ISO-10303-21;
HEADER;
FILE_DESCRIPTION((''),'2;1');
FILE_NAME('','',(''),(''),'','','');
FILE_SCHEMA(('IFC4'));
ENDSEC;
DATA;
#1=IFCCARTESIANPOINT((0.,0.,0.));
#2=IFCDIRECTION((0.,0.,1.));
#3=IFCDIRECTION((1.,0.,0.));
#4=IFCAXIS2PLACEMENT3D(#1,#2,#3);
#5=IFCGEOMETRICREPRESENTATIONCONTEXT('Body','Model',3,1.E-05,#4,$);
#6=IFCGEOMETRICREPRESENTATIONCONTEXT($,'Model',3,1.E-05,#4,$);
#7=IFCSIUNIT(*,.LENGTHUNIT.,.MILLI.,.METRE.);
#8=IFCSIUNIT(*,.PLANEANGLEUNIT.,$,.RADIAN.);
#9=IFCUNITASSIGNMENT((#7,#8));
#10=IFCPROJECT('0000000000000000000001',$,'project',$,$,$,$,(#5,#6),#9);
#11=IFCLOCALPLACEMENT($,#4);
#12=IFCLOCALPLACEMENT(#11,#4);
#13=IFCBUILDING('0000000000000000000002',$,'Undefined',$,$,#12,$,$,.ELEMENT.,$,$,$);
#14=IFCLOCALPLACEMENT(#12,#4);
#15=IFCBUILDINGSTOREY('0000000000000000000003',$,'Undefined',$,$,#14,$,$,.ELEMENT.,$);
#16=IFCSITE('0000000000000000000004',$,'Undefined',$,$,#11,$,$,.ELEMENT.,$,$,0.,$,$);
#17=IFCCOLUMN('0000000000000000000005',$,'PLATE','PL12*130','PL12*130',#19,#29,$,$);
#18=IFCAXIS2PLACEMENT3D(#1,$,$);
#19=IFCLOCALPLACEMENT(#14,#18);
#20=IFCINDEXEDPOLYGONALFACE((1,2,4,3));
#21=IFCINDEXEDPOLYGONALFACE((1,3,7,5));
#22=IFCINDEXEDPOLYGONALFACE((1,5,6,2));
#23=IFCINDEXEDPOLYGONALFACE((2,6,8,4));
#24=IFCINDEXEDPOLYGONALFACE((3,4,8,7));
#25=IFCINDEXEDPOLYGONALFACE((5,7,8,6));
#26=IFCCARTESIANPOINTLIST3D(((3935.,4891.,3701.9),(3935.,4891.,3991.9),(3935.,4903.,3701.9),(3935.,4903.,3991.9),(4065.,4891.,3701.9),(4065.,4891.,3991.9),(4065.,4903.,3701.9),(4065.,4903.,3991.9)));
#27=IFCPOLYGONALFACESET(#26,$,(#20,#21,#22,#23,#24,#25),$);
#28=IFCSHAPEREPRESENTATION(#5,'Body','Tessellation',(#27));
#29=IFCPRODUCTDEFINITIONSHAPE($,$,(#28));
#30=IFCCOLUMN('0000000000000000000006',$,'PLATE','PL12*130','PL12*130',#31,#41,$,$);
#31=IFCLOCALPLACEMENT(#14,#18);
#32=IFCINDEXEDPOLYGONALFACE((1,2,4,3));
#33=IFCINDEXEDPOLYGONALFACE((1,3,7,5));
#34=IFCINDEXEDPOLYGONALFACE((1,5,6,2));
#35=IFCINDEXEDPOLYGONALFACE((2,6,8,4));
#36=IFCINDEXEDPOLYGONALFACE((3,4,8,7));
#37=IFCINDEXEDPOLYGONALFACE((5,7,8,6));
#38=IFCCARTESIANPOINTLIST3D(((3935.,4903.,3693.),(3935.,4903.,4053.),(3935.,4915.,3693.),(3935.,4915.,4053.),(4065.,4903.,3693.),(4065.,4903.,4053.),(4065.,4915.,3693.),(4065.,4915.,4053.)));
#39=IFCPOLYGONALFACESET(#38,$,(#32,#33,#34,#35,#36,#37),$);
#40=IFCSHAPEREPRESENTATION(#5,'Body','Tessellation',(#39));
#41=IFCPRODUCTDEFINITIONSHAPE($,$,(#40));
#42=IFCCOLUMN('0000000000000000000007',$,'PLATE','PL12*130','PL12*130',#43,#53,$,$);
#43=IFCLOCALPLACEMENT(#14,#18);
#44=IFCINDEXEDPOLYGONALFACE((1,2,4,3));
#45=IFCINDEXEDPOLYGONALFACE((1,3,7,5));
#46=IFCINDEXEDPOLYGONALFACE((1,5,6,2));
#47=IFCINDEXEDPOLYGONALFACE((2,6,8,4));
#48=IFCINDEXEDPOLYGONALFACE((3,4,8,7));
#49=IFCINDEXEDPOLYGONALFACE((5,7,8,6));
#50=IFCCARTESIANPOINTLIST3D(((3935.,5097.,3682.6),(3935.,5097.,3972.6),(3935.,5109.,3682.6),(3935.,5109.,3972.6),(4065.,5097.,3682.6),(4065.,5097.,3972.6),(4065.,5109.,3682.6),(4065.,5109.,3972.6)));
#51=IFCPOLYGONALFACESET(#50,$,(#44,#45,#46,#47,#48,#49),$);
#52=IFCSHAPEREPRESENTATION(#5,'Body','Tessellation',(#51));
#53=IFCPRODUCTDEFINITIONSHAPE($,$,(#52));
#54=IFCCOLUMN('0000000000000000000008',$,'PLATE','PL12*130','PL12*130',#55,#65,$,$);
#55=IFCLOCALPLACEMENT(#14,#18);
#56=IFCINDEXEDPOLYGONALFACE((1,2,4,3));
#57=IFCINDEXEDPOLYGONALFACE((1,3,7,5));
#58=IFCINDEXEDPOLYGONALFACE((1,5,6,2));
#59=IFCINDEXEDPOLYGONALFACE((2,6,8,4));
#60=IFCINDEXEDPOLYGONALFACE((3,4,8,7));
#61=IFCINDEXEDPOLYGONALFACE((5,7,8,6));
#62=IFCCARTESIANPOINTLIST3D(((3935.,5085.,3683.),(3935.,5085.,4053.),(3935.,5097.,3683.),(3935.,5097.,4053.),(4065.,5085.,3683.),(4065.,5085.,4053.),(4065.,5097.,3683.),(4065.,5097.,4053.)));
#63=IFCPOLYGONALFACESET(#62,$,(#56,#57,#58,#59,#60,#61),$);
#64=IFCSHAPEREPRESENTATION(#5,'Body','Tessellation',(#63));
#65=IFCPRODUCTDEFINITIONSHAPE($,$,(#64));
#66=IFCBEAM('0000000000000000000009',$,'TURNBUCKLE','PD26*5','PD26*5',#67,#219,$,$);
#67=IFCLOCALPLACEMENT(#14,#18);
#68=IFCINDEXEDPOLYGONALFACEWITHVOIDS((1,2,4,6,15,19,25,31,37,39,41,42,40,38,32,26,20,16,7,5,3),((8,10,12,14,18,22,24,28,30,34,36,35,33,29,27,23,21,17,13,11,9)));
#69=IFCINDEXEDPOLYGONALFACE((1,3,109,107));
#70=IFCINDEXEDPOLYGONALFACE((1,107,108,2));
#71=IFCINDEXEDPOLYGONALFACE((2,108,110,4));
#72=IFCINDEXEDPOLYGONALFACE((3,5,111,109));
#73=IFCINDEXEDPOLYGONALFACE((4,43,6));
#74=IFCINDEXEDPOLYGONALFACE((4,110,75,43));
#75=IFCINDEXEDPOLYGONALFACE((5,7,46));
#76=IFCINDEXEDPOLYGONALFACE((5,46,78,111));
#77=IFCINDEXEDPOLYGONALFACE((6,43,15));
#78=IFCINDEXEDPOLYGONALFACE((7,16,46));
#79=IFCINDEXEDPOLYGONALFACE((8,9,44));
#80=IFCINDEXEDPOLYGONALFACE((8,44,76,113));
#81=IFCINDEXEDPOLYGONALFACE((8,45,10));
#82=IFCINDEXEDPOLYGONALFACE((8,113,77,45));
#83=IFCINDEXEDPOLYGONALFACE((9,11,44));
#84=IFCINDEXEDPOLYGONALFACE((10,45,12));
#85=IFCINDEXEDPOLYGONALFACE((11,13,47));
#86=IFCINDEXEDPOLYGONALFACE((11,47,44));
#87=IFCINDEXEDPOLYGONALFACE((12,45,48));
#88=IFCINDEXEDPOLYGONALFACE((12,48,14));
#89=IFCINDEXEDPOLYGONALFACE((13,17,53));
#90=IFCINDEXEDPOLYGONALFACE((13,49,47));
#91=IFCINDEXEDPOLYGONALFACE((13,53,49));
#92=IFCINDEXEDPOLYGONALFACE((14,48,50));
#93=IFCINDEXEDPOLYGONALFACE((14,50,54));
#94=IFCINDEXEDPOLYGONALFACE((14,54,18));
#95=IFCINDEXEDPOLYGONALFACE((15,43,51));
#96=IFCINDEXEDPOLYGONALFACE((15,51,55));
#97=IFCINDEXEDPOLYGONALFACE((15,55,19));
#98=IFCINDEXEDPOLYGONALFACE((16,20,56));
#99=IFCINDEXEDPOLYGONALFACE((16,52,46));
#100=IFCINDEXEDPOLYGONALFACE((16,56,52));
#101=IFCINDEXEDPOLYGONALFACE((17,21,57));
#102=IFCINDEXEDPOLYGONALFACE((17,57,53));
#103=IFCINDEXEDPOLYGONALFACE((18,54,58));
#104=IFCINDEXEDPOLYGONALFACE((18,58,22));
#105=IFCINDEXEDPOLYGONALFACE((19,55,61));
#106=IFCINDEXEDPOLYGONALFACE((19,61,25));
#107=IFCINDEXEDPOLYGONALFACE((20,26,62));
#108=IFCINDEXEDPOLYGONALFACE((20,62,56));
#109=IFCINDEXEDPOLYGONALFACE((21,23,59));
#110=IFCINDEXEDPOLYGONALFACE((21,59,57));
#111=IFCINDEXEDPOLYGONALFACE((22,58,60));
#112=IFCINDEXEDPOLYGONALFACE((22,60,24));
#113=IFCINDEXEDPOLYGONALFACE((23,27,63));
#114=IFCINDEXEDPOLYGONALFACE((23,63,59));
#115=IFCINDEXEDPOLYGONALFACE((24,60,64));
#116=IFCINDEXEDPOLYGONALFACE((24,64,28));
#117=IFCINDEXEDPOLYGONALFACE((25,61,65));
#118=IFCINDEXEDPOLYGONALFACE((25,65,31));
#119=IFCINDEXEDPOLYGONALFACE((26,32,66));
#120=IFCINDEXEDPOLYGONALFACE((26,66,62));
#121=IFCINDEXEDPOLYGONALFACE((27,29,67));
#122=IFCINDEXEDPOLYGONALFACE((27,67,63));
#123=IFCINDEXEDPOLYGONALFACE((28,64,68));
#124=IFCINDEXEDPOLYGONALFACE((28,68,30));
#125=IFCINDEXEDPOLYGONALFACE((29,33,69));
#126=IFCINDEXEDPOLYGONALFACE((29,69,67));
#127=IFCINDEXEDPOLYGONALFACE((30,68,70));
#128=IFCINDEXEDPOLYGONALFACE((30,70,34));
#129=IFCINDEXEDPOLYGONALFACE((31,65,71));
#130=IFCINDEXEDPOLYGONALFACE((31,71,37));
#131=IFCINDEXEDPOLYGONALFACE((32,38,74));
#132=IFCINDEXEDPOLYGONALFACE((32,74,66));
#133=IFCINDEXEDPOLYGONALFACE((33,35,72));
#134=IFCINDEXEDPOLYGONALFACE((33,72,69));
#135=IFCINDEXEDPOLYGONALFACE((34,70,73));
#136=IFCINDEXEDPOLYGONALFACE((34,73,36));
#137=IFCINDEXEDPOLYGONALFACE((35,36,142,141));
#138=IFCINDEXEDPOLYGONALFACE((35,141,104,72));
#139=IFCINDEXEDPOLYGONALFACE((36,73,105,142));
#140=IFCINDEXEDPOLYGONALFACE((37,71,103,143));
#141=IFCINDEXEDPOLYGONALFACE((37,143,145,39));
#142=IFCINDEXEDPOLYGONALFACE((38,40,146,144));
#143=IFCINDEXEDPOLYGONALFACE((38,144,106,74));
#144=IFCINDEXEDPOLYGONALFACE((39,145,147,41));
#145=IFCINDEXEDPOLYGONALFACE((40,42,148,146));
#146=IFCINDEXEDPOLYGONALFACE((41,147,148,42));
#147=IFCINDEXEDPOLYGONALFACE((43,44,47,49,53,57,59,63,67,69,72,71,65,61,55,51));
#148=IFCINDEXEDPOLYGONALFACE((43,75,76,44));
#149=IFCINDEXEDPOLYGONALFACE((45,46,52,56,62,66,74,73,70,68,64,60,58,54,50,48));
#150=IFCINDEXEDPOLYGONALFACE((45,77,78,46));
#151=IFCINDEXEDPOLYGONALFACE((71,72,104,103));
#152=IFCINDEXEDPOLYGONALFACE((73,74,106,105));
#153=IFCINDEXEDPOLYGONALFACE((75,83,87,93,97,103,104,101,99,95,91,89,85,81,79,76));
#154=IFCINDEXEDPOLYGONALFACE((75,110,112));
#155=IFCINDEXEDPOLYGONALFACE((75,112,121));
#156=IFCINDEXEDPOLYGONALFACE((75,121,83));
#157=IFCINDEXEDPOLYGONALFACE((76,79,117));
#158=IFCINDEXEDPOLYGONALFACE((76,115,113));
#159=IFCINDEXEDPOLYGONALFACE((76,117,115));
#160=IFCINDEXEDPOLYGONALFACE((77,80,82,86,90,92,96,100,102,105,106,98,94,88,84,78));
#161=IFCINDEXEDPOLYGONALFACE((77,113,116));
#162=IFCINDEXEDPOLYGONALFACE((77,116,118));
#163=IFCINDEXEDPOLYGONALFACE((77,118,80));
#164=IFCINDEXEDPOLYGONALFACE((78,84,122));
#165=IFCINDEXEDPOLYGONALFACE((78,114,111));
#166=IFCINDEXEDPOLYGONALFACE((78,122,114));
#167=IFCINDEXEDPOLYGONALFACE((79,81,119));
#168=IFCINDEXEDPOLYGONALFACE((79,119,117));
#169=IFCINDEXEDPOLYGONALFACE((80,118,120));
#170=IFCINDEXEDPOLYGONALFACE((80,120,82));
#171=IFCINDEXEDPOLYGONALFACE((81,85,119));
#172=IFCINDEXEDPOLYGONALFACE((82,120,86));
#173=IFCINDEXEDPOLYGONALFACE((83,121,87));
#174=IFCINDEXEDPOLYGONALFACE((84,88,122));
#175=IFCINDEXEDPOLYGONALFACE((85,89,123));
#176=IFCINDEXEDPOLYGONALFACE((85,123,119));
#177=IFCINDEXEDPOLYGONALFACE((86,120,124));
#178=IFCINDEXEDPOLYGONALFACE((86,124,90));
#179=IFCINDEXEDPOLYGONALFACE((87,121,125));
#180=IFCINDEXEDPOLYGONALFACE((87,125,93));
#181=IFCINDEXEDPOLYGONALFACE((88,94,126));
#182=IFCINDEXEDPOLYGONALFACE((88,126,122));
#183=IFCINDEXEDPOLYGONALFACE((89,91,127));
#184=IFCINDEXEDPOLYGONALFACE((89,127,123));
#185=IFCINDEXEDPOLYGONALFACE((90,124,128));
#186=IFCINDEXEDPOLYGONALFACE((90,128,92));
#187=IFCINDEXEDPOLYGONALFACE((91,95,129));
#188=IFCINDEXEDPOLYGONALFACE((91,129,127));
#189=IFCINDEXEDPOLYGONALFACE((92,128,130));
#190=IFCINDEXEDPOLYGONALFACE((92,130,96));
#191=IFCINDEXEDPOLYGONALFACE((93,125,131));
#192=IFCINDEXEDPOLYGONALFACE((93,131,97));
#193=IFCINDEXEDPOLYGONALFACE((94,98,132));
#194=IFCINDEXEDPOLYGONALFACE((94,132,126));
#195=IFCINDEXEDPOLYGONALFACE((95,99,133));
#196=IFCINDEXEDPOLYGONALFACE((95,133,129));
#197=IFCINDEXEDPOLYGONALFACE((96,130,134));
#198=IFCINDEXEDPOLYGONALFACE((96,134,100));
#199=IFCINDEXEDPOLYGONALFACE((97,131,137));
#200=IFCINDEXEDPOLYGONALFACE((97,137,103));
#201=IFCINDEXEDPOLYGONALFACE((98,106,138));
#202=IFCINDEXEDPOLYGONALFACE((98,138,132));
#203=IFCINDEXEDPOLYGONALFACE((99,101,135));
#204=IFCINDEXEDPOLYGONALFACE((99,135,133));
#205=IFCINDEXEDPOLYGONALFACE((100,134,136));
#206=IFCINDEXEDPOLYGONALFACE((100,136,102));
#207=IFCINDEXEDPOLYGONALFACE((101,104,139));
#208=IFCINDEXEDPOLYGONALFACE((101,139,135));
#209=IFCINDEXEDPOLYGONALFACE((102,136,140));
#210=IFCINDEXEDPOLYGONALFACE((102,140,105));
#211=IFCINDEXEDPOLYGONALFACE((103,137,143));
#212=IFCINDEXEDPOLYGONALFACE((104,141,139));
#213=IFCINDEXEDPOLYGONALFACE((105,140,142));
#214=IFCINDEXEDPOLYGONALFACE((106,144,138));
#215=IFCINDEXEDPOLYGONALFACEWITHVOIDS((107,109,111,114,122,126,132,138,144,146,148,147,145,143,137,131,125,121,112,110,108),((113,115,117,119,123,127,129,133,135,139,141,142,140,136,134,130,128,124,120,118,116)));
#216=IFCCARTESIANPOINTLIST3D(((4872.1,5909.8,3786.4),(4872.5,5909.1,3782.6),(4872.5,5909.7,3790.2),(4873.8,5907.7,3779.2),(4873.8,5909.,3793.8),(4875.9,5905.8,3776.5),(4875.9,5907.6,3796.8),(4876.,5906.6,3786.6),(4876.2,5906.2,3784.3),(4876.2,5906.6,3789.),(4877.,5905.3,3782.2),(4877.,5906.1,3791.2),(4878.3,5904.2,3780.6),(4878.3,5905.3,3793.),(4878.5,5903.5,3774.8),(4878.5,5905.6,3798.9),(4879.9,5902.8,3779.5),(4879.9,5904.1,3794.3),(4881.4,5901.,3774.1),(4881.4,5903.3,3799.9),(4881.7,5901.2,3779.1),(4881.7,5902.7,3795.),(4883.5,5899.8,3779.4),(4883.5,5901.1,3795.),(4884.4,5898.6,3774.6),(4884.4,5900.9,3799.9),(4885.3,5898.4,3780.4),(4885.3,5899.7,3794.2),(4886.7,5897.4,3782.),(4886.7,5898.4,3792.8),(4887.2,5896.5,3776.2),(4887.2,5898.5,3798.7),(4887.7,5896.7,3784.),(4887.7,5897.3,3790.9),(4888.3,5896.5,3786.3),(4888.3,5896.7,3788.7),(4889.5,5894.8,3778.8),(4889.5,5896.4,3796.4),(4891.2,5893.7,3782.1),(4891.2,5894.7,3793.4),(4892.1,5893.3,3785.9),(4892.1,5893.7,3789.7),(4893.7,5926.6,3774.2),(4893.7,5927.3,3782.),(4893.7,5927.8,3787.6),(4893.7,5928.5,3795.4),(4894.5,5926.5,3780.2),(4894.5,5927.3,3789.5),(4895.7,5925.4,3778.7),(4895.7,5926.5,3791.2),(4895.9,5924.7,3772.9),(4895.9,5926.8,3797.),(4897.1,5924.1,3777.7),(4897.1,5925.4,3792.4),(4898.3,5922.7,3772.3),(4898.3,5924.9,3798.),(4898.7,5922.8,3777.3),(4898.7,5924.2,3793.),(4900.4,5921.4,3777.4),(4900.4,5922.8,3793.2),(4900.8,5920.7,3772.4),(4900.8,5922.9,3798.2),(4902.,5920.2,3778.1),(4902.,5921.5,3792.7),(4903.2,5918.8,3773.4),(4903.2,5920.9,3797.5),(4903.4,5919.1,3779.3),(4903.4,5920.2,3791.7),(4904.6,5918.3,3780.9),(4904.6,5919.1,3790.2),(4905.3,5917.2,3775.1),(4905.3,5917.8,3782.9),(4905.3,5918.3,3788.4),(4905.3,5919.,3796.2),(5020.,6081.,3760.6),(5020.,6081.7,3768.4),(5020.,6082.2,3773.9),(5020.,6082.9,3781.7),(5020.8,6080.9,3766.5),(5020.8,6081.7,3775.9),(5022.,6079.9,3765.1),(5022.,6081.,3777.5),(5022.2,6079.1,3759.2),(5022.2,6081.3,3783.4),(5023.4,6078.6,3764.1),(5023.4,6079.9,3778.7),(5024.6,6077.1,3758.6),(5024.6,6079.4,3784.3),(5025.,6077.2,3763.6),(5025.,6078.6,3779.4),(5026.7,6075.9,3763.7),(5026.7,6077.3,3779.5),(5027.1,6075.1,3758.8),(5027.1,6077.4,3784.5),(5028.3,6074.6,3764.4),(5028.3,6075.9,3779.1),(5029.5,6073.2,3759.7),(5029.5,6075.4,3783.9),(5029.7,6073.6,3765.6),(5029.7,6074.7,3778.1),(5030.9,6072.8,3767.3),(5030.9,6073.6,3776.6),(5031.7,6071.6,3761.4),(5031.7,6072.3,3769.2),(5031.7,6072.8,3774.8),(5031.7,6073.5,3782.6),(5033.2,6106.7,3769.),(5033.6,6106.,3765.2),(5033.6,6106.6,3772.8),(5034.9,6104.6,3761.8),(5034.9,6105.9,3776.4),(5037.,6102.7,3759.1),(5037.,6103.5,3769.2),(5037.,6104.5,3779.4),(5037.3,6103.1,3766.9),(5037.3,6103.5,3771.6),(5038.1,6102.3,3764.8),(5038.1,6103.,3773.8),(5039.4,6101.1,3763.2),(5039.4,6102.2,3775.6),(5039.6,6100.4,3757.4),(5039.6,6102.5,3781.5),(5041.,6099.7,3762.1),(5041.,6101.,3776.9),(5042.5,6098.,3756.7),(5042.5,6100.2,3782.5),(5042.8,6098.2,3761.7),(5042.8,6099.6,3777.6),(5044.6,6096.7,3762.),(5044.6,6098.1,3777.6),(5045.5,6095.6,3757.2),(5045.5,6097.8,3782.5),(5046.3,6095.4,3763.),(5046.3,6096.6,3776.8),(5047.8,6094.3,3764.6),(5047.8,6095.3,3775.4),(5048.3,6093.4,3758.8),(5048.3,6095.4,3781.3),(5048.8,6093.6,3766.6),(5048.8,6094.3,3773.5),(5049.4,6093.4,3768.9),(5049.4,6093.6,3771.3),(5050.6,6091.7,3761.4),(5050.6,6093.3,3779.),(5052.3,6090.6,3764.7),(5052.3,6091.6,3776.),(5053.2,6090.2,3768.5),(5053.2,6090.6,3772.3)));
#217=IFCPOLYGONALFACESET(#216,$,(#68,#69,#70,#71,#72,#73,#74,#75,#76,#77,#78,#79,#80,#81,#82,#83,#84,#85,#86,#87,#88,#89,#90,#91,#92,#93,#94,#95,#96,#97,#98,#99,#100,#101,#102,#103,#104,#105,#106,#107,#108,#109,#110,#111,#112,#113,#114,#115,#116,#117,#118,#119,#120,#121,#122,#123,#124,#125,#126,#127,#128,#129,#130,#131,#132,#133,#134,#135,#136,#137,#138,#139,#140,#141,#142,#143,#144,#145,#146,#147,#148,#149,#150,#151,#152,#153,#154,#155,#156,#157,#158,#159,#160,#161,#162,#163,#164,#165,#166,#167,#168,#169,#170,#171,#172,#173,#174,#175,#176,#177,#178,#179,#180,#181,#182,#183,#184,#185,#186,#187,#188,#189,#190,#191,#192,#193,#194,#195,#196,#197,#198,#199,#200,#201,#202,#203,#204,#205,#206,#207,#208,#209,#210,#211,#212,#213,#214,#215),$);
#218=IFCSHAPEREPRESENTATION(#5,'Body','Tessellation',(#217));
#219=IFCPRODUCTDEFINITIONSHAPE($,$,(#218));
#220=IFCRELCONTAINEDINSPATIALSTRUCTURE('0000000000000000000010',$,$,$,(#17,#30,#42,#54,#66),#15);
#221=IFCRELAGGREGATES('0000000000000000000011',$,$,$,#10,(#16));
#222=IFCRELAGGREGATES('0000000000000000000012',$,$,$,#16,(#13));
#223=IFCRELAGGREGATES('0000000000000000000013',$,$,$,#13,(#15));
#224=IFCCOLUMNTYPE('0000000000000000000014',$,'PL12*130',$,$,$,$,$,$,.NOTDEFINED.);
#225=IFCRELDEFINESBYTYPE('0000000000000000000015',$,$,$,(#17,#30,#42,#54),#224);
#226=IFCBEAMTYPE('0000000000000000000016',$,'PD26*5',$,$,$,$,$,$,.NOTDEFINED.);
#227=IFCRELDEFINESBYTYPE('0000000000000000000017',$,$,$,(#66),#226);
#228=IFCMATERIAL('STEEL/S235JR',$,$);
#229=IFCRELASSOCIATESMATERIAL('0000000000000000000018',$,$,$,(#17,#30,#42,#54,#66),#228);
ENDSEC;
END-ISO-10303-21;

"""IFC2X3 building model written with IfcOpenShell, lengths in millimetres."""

from ifc_helpers import new_model, si_unit, frame, origin_with_axes, origin_2d_with_axis, place, context, project, spatial, rectangle, hollow_circle, extrude, material, type_object, element, save


model = new_model("IFC2X3")

# Units and contexts
model_context_1 = context("Model", 3, precision=1e-05, world=origin_with_axes(), identifier="Body")
model_context_2 = context("Model", 3, precision=1e-05, world=origin_with_axes())
ifc_project = project(units=[si_unit("LENGTHUNIT", "METRE", prefix="MILLI"), si_unit("PLANEANGLEUNIT", "RADIAN")], contexts=[model_context_1, model_context_2])

# Site, building, storey
site_placement = place(None, origin_with_axes())
site = spatial("IfcSite", under=ifc_project, at=site_placement, Name="Undefined", CompositionType="ELEMENT", RefElevation=0.0)
building_placement = place(site_placement, origin_with_axes())
building = spatial("IfcBuilding", under=site, at=building_placement, Name="Undefined", CompositionType="ELEMENT")
storey_placement = place(building_placement, origin_with_axes())
storey = spatial("IfcBuildingStorey", under=building, at=storey_placement, Name="Undefined", CompositionType="ELEMENT")

# Columns
ifc_material = material(Name="STEEL/S235JR")
column_type = type_object("IfcColumnType", Name="PL12*130", PredefinedType="NOTDEFINED")
column_1_placement = place(storey_placement, frame((4000.0, 4897.0, 3701.9), z_axis=(0.0, 0.0, 1.0), x_axis=(1.0, 0.0, 0.0)))
element("IfcColumn", 1, at=column_1_placement, inside=storey, type_object=column_type, material=ifc_material, Name="PLATE", Description="PL12*130", ObjectType="PL12*130", context=model_context_1, shape_type="SweptSolid", body=[
    extrude(rectangle(XDim=12.0, YDim=130.0, at=origin_2d_with_axis()), frame((0.0, 0.0, 290.0), z_axis=(0.0, 0.0, -1.0), x_axis=(0.0, 1.0, 0.0)), (0.0, 0.0, 1.0), 290.0),
])
column_2_placement = place(storey_placement, frame((4000.0, 4909.0, 3693.0), z_axis=(0.0, 0.0, 1.0), x_axis=(1.0, 0.0, 0.0)))
element("IfcColumn", 2, at=column_2_placement, inside=storey, type_object=column_type, material=ifc_material, Name="PLATE", Description="PL12*130", ObjectType="PL12*130", context=model_context_1, shape_type="SweptSolid", body=[
    extrude(rectangle(XDim=12.0, YDim=130.0, at=origin_2d_with_axis()), frame((0.0, 0.0, 360.0), z_axis=(0.0, 0.0, -1.0), x_axis=(0.0, 1.0, 0.0)), (0.0, 0.0, 1.0), 360.0),
])
column_3_placement = place(storey_placement, frame((4000.0, 5103.0, 3682.6), z_axis=(0.0, 0.0, 1.0), x_axis=(1.0, 0.0, 0.0)))
element("IfcColumn", 3, at=column_3_placement, inside=storey, type_object=column_type, material=ifc_material, Name="PLATE", Description="PL12*130", ObjectType="PL12*130", context=model_context_1, shape_type="SweptSolid", body=[
    extrude(rectangle(XDim=12.0, YDim=130.0, at=origin_2d_with_axis()), frame((0.0, 0.0, 290.0), z_axis=(0.0, 0.0, -1.0), x_axis=(0.0, 1.0, 0.0)), (0.0, 0.0, 1.0), 290.0),
])
column_4_placement = place(storey_placement, frame((4000.0, 5091.0, 3683.0), z_axis=(0.0, 0.0, 1.0), x_axis=(1.0, 0.0, 0.0)))
element("IfcColumn", 4, at=column_4_placement, inside=storey, type_object=column_type, material=ifc_material, Name="PLATE", Description="PL12*130", ObjectType="PL12*130", context=model_context_1, shape_type="SweptSolid", body=[
    extrude(rectangle(XDim=12.0, YDim=130.0, at=origin_2d_with_axis()), frame((0.0, 0.0, 370.0), z_axis=(0.0, 0.0, -1.0), x_axis=(0.0, 1.0, 0.0)), (0.0, 0.0, 1.0), 370.0),
])

# Beam, opening
beam_type_1 = type_object("IfcBeamType", Name="PD26*5", PredefinedType="NOTDEFINED")
beam_1_placement = place(storey_placement, frame((4882.2, 5901.6, 3787.1), z_axis=(0.0, -0.088027, -0.996118), x_axis=(0.631673, 0.772225, -0.068242)))
beam_1 = element("IfcBeam", 5, at=beam_1_placement, inside=storey, type_object=beam_type_1, material=ifc_material, Name="TURNBUCKLE", Description="PD26*5", ObjectType="PD26*5", context=model_context_1, shape_type="SweptSolid", body=[
    extrude(hollow_circle(Radius=13.0, WallThickness=5.0, at=origin_2d_with_axis()), frame((255.0, 0.0, 0.0), z_axis=(-1.0, 0.0, 0.0), x_axis=(0.0, -1.0, 0.0)), (0.0, 0.0, 1.0), 255.0),
])
opening_placement = place(storey_placement, frame((4882.2, 5901.6, 3787.1), z_axis=(0.0, -0.088027, -0.996118), x_axis=(0.631673, 0.772225, -0.068242)))
element("IfcOpeningElement", 6, at=opening_placement, cuts=beam_1, ObjectType="Recess", context=model_context_1, shape_type="SweptSolid", body=[
    extrude(rectangle(XDim=15.0, YDim=52.0, at=origin_2d_with_axis()), frame((227.5, 0.0, 0.0), z_axis=(-1.0, 0.0, 0.0), x_axis=(0.0, -1.0, 0.0)), (0.0, 0.0, 1.0), 200.0),
])

save(model, "model.ifc")
